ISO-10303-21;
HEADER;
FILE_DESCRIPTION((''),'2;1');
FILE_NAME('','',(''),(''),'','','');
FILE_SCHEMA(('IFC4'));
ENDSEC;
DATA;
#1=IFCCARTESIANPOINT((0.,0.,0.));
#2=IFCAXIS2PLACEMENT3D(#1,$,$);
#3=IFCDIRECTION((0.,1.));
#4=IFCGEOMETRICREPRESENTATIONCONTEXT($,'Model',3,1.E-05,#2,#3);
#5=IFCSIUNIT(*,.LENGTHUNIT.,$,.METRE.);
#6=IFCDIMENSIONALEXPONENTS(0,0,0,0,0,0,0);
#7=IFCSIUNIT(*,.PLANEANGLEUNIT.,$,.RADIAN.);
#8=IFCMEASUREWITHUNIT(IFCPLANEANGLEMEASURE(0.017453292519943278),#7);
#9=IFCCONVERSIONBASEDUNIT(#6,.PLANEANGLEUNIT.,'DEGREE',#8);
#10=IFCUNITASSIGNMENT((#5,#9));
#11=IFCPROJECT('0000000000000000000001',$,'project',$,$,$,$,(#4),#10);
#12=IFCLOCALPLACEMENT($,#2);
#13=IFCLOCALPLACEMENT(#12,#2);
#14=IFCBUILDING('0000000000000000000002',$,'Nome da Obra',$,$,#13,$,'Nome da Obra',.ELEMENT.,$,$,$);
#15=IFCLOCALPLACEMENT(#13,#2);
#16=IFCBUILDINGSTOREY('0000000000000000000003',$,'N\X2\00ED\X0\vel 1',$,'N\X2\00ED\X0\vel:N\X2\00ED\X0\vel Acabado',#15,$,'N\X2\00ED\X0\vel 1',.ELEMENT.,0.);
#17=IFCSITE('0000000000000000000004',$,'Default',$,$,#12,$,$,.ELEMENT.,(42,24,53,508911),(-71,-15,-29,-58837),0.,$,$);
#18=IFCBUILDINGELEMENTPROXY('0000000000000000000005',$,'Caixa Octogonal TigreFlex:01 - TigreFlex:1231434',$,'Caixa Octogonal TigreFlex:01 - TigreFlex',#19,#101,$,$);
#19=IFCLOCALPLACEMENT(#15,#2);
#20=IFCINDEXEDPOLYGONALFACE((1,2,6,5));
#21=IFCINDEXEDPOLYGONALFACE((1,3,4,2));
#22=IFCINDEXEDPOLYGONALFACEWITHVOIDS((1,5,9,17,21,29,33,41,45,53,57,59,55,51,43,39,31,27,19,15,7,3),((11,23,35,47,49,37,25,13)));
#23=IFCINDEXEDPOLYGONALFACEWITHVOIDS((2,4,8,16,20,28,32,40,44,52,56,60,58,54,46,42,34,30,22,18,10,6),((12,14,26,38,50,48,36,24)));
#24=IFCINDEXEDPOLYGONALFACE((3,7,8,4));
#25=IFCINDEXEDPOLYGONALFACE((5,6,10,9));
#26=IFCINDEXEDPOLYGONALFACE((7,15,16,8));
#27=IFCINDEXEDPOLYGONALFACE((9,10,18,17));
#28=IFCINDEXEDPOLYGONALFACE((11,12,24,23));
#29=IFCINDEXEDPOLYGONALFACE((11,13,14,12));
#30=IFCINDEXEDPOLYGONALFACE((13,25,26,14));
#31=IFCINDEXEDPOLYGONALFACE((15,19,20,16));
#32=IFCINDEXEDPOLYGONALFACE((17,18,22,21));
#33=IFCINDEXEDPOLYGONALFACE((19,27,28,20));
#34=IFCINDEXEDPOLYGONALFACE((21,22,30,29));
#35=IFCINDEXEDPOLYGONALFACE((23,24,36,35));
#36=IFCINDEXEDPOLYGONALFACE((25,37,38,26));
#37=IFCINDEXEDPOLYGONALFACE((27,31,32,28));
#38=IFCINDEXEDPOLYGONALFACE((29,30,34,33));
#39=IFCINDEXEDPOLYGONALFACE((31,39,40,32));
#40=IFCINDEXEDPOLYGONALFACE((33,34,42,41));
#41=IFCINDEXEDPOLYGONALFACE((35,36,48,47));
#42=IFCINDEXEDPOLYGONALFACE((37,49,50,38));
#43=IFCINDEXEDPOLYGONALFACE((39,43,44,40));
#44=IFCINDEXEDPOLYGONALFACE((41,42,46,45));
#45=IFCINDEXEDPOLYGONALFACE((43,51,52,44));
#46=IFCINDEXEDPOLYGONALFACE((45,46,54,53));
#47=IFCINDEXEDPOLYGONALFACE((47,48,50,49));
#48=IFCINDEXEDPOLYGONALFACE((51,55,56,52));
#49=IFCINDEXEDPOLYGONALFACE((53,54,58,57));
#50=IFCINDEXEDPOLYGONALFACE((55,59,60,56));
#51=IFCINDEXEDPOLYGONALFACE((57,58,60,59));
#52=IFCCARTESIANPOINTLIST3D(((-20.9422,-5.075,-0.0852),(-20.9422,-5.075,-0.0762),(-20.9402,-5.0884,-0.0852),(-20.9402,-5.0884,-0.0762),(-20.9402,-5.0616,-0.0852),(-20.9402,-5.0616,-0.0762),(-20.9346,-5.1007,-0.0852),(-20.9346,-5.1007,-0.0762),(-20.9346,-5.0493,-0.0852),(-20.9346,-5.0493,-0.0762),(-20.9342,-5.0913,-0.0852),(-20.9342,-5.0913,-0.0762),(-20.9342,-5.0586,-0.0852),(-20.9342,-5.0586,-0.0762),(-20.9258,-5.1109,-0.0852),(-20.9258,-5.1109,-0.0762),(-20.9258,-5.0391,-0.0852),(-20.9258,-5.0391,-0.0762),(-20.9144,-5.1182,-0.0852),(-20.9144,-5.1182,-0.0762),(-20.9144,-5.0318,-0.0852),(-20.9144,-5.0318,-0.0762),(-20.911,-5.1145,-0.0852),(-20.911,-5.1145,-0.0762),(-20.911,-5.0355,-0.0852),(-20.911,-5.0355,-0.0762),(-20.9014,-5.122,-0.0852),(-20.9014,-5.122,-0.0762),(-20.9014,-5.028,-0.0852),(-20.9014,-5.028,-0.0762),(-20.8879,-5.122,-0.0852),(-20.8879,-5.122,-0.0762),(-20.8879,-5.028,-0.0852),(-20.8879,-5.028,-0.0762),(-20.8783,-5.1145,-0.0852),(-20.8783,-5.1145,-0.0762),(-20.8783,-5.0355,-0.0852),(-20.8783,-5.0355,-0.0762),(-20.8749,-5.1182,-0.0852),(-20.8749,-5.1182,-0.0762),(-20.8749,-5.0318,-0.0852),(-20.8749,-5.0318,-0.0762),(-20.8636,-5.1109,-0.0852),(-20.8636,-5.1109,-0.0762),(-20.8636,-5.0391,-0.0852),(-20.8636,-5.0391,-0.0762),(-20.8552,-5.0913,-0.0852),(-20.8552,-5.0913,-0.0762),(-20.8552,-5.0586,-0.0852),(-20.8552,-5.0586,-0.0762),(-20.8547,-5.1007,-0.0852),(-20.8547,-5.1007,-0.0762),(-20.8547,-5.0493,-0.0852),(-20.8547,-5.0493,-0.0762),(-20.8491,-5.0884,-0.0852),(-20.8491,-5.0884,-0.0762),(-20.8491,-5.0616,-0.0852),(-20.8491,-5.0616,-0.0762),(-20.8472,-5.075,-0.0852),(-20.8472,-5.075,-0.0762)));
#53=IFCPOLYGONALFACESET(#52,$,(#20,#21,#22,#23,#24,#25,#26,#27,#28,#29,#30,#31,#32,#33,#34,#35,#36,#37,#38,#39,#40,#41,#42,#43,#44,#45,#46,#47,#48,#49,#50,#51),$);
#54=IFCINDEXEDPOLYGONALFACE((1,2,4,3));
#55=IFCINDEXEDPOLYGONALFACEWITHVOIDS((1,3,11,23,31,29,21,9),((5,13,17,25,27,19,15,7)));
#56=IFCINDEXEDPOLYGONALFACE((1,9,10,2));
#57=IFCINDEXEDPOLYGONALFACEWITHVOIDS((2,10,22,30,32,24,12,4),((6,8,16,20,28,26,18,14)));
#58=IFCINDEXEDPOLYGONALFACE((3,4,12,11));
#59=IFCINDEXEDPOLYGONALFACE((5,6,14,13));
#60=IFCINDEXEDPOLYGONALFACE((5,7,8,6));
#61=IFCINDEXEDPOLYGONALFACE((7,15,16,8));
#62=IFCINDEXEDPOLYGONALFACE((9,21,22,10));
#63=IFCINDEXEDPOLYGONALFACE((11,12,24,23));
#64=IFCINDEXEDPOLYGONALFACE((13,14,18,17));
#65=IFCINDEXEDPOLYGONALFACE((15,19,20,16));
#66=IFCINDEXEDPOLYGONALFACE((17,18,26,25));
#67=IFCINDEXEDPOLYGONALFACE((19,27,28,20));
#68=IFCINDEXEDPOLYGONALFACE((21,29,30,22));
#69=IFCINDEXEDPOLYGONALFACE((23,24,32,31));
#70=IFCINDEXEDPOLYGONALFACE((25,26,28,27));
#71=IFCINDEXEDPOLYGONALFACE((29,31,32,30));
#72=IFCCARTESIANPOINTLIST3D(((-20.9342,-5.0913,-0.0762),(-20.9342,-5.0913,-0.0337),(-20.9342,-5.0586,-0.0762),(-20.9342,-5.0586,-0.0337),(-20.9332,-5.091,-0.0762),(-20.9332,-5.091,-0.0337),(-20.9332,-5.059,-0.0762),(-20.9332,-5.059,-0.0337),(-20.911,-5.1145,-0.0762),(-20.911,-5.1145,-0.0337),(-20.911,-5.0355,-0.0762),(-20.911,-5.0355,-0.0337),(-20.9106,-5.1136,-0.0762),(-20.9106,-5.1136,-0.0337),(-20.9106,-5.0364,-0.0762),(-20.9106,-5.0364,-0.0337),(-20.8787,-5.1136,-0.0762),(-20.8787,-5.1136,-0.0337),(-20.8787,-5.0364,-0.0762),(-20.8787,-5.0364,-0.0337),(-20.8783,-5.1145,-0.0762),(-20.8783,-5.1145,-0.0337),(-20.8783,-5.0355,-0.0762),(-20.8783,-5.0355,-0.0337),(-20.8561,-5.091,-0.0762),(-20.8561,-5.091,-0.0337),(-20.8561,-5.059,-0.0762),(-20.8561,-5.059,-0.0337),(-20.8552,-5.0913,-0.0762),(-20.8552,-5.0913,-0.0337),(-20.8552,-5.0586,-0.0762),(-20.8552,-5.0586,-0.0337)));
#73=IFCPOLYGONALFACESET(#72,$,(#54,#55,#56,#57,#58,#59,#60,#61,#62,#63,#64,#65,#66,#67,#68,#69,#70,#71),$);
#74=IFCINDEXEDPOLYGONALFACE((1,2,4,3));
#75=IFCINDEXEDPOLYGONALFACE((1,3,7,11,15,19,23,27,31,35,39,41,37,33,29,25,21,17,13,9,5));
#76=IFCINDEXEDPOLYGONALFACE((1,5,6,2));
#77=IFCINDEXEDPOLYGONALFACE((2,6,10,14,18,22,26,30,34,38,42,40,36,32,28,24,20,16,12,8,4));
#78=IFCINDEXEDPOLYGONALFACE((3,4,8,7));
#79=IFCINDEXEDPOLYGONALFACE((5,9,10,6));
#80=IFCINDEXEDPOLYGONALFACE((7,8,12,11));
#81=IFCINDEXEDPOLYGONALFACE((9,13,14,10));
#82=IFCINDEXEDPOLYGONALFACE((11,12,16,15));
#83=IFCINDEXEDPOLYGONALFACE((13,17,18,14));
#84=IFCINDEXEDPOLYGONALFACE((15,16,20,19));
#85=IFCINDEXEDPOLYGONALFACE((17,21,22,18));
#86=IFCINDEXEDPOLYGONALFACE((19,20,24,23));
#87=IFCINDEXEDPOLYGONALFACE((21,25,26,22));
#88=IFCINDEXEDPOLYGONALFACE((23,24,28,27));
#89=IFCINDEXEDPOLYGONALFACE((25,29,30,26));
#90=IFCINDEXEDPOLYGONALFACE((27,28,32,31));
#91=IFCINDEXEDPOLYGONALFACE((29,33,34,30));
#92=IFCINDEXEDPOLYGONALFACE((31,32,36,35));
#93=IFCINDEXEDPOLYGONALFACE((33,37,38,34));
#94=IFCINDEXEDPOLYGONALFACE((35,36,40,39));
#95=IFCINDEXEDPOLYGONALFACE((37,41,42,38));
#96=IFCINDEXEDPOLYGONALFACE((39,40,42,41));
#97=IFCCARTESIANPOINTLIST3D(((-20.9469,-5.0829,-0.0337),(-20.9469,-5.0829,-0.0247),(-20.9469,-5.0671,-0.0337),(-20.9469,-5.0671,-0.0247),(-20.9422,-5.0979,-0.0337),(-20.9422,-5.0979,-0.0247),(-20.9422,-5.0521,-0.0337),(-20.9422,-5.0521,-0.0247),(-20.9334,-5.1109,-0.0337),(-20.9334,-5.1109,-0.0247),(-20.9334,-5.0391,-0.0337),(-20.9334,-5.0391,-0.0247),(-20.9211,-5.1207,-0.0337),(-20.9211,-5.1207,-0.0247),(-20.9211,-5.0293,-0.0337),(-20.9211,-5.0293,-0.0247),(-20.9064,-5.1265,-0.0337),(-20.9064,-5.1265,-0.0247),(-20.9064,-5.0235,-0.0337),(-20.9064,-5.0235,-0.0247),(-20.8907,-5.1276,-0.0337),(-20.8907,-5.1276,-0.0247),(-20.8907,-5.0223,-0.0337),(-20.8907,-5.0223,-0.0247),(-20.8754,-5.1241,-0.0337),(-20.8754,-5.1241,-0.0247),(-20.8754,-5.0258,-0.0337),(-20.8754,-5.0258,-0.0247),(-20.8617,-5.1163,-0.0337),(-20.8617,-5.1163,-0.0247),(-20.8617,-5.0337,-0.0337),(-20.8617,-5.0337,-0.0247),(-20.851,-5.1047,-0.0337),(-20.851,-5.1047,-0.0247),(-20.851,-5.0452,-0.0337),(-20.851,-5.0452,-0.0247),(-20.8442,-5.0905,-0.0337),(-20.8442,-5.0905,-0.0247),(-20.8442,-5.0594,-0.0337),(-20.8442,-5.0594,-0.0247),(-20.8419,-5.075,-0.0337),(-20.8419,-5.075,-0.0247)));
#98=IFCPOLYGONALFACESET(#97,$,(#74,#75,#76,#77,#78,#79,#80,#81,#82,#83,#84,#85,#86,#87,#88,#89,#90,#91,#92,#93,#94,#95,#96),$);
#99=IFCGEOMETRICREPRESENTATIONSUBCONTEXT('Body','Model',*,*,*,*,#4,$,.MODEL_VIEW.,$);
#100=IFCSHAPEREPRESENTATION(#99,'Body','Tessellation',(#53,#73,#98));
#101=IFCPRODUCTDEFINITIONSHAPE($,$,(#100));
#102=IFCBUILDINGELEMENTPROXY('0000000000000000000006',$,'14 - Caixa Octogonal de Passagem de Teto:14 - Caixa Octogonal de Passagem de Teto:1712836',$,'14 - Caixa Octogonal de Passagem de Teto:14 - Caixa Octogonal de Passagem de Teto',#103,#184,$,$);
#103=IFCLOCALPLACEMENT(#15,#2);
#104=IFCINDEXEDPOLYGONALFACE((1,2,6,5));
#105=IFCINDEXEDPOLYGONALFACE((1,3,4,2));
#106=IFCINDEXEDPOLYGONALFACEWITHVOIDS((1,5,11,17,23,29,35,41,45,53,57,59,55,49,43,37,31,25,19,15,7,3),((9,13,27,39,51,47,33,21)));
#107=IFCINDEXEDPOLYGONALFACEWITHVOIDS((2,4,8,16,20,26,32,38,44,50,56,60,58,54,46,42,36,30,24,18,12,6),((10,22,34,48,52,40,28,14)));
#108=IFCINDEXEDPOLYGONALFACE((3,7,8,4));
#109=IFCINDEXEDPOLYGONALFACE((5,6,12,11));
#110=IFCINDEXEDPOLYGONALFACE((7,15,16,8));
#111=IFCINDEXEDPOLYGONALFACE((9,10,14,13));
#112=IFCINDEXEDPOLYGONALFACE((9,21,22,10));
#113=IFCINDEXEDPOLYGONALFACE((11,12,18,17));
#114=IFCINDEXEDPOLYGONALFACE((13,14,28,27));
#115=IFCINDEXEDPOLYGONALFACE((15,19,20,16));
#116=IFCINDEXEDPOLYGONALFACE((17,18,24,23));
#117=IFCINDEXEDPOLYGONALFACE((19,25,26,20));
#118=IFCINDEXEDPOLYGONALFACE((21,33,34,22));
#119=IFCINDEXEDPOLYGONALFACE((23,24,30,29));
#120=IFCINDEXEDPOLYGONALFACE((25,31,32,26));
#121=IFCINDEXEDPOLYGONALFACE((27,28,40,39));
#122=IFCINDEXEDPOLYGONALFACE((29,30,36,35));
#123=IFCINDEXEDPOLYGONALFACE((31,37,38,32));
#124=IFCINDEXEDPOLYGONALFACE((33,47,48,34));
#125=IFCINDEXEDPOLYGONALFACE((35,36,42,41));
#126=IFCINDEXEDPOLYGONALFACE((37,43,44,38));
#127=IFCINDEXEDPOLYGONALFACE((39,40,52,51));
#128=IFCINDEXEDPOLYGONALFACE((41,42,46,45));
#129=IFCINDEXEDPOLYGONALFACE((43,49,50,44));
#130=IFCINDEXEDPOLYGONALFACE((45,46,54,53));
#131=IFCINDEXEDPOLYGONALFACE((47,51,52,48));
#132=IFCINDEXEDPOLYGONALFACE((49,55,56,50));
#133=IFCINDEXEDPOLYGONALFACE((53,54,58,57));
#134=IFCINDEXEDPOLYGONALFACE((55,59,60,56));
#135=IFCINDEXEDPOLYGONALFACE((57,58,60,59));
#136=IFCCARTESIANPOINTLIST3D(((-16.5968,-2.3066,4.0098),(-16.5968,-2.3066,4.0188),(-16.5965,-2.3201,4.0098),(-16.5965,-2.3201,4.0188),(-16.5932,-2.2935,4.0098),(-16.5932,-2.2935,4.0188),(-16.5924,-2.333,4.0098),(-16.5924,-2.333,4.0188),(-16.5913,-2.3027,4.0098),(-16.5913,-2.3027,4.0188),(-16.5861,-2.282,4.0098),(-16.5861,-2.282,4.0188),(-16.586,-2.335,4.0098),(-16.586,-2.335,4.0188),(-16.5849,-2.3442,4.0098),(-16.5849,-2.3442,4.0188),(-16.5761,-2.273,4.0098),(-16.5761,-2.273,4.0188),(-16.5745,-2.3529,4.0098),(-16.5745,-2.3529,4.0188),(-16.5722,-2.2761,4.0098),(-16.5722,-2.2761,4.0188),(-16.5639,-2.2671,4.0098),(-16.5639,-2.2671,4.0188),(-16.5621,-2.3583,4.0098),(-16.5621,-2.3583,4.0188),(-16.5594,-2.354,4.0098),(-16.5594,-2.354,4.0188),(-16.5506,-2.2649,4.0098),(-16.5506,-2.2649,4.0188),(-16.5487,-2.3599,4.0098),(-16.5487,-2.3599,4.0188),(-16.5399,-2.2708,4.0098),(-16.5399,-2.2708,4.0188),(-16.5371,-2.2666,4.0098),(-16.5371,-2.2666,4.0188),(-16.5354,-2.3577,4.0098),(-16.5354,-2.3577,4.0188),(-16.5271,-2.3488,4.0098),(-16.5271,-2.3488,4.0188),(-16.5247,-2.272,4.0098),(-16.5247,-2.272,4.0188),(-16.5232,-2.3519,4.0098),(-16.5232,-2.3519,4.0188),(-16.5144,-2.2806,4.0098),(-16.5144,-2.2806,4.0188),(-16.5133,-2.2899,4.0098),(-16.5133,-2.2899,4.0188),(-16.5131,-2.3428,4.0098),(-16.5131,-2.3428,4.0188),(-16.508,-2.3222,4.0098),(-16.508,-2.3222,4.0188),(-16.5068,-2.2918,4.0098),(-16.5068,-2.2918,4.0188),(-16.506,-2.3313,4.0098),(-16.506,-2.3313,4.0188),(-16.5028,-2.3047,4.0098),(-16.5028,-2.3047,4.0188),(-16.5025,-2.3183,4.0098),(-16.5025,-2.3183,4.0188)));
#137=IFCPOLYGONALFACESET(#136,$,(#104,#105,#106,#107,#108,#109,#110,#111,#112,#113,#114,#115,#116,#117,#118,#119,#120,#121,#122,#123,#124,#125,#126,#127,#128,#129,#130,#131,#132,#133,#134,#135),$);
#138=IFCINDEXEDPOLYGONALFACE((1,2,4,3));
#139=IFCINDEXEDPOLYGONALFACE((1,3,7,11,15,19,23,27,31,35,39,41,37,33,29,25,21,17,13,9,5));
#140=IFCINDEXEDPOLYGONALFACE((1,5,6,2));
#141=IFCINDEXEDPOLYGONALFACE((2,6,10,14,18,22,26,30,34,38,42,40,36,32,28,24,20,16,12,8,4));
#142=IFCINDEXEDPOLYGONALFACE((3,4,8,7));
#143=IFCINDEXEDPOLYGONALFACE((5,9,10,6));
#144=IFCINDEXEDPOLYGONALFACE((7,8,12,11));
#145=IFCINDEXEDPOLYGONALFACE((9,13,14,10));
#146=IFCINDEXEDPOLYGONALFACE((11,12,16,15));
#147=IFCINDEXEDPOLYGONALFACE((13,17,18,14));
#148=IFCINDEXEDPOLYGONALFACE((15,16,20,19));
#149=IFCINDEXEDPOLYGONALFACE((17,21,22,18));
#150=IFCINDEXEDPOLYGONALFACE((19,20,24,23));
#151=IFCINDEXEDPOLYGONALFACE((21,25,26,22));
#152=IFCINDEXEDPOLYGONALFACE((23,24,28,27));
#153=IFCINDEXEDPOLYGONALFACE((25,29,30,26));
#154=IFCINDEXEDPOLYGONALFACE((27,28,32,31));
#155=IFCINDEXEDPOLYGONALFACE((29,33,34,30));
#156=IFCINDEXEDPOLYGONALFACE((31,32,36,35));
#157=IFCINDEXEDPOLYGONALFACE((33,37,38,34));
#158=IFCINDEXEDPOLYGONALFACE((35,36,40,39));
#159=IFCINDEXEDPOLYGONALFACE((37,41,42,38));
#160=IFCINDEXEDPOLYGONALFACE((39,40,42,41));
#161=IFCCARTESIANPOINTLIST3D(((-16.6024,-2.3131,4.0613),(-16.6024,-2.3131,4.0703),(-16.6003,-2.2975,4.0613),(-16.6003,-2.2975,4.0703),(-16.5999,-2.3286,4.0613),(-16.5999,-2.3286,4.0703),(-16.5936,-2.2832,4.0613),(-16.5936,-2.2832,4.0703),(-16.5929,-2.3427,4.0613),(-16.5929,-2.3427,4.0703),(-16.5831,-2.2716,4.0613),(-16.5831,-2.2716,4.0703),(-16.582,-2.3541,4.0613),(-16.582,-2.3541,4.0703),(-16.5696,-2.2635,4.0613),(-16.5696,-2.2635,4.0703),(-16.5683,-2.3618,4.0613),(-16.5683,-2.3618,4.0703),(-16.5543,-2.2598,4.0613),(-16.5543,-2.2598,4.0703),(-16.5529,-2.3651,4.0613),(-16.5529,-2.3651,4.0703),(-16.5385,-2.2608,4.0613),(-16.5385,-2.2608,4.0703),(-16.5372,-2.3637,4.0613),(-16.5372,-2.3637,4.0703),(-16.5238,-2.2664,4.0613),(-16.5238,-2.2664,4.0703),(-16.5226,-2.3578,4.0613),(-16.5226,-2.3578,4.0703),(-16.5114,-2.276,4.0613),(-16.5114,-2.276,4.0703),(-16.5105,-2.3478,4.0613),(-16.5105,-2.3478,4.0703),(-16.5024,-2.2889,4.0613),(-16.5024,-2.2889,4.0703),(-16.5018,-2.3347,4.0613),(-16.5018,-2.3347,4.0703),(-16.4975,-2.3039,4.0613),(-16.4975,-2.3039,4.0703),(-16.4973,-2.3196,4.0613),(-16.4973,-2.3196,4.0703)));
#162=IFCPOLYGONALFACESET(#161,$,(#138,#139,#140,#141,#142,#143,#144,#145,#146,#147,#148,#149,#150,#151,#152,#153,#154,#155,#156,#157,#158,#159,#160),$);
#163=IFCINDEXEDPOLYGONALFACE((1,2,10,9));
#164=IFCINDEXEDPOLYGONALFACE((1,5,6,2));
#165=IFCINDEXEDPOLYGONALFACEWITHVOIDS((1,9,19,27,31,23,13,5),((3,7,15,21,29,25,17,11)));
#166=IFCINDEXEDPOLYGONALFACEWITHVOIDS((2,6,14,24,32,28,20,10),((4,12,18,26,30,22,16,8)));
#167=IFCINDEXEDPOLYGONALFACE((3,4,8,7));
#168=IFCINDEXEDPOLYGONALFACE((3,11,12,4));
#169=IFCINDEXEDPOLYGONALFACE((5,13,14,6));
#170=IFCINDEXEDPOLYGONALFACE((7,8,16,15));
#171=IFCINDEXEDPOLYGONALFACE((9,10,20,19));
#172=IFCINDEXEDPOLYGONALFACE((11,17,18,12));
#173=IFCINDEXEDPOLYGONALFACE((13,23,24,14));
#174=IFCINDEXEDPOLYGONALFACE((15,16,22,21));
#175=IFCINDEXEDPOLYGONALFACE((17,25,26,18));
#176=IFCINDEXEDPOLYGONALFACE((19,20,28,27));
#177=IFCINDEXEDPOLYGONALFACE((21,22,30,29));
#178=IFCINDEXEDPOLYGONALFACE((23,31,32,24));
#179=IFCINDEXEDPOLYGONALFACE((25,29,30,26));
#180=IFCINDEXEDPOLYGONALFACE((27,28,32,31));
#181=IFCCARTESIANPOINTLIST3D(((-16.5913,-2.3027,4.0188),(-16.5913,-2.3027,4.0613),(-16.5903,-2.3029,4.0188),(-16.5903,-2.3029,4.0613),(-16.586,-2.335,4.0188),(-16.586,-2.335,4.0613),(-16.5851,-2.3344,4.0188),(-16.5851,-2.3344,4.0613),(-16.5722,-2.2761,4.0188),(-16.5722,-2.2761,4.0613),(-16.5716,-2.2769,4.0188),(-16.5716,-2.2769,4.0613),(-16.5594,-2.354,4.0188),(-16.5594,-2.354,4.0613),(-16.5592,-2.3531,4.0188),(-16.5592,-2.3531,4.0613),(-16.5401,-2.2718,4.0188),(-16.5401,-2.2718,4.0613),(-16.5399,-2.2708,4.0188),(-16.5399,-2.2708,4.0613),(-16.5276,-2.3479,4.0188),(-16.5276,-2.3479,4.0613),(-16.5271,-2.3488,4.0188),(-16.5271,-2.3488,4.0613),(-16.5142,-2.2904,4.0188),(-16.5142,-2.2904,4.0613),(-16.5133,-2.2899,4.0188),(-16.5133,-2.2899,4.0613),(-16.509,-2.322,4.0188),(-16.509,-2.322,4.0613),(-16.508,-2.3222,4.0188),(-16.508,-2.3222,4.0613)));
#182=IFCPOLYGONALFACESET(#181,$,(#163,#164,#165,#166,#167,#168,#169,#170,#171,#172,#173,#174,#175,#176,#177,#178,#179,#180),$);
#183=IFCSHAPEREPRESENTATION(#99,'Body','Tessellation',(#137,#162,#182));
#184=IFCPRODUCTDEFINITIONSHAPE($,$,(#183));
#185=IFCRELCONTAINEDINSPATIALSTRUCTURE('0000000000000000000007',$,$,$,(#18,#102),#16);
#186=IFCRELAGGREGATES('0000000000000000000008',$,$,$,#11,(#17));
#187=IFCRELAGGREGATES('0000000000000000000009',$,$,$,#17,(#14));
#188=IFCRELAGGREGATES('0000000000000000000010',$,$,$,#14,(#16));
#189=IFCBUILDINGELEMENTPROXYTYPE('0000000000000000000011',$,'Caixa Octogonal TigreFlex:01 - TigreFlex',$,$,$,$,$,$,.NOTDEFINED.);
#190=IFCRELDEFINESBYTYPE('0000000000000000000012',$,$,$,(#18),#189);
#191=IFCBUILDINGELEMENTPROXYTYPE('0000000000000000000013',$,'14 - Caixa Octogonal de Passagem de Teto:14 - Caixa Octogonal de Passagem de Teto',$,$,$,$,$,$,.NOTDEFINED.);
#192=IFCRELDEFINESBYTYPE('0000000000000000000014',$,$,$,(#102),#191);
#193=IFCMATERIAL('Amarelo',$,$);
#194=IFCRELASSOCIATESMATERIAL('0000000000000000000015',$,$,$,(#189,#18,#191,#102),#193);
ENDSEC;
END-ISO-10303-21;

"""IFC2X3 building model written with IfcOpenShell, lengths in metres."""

from ifc_helpers import new_model, entity, si_unit, converted_unit, direction, frame, frame_2d, origin, origin_2d_with_axis, place, context, subcontext, project, spatial, polyline, circle_curve, parameter, trimmed, segment, composite_curve, circle, outline, extrude, source, transform, mapped, material, type_object, type_shapes, element, save


model = new_model("IFC2X3")

# Units and contexts
model_context = context("Model", 3, precision=1e-05, world=origin(), true_north=direction((0.0, 1.0)))
body_context = subcontext(model_context, "Body", "Model", "MODEL_VIEW")
ifc_project = project(units=[si_unit("LENGTHUNIT", "METRE"), converted_unit("PLANEANGLEUNIT", "DEGREE", entity("IfcPlaneAngleMeasure", 0.017453292519943278), si_unit("PLANEANGLEUNIT", "RADIAN"), dimensions=[0, 0, 0, 0, 0, 0, 0])], contexts=[model_context])

# Site, building, storey
site_placement = place(None, origin())
site = spatial("IfcSite", under=ifc_project, at=site_placement, Name="Default", CompositionType="ELEMENT", RefLatitude=(42, 24, 53, 508911), RefLongitude=(-71, -15, -29, -58837), RefElevation=0.0)
building_placement = place(site_placement, origin())
building = spatial("IfcBuilding", under=site, at=building_placement, Name="Nome da Obra", LongName="Nome da Obra", CompositionType="ELEMENT")
storey_placement = place(building_placement, origin())
storey = spatial("IfcBuildingStorey", under=building, at=storey_placement, Name="Nível 1", ObjectType="Nível:Nível Acabado", LongName="Nível 1", CompositionType="ELEMENT", Elevation=0.0)

# Building element proxies
ifc_material_1 = material(Name="Amarelo")
building_element_proxy_type_1 = type_object("IfcBuildingElementProxyType", Name="Caixa Octogonal TigreFlex:01 - TigreFlex", PredefinedType="NOTDEFINED", material=ifc_material_1)
shared_shape_1 = source(origin(), body_context, "Body", "SweptSolid", [
    extrude(outline(composite_curve([segment(trimmed(circle_curve(origin_2d_with_axis(), 0.0475), [parameter(180.0)], [parameter(360.0)], True, "PARAMETER"), True, "CONTINUOUS"), segment(trimmed(circle_curve(origin_2d_with_axis(), 0.0475), [parameter(0.0)], [parameter(180.0)], True, "PARAMETER"), True, "CONTINUOUS")], self_intersect=False), holes=[polyline([(-0.0395, 0.0164), (-0.0164, 0.0395), (0.0164, 0.0395), (0.0395, 0.0164), (0.0395, -0.0164), (0.0164, -0.0395), (-0.0164, -0.0395), (-0.0395, -0.0164), (-0.0395, 0.0164)])]), frame((0.0, 0.0, -0.0302)), (0.0, 0.0, 1.0), 0.009),
    extrude(outline(polyline([(-0.0164, -0.0395), (0.0164, -0.0395), (0.0395, -0.0164), (0.0395, 0.0164), (0.0164, 0.0395), (-0.0164, 0.0395), (-0.0395, 0.0164), (-0.0395, -0.0164), (-0.0164, -0.0395)]), holes=[polyline([(-0.016, -0.0386), (-0.0386, -0.016), (-0.0386, 0.016), (-0.016, 0.0386), (0.016, 0.0386), (0.0386, 0.016), (0.0386, -0.016), (0.016, -0.0386), (-0.016, -0.0386)])]), frame((0.0, 0.0, -0.0212), z_axis=(0.0, 0.0, 1.0), x_axis=(0.0, -1.0, 0.0)), (0.0, 0.0, 1.0), 0.0425),
    extrude(circle(Radius=0.0528, at=frame_2d((0.0, 0.0), x_axis=(1.0, 0.0))), frame((0.0, 0.0, 0.0213)), (0.0, 0.0, 1.0), 0.009),
])
type_shapes(building_element_proxy_type_1, [shared_shape_1])
for number, where, name in (
    (1, (-20.8947, -5.075, -0.055), "Caixa Octogonal TigreFlex:01 - TigreFlex:1231434"),
):
    element("IfcBuildingElementProxy", number, at=place(storey_placement, frame(where)), inside=storey, type_object=building_element_proxy_type_1, material=ifc_material_1, Name=name, ObjectType="Caixa Octogonal TigreFlex:01 - TigreFlex", context=body_context, shape_type="MappedRepresentation", body=[
        mapped(shared_shape_1, transform((0.0, 0.0, 0.0), scale=1.0)),
    ])
building_element_proxy_type_2 = type_object("IfcBuildingElementProxyType", Name="14 - Caixa Octogonal de Passagem de Teto:14 - Caixa Octogonal de Passagem de Teto", PredefinedType="NOTDEFINED", material=ifc_material_1)
shared_shape_2 = source(origin(), body_context, "Body", "SweptSolid", [
    extrude(outline(composite_curve([segment(trimmed(circle_curve(origin_2d_with_axis(), 0.0475), [parameter(180.0)], [parameter(360.0)], True, "PARAMETER"), True, "CONTINUOUS"), segment(trimmed(circle_curve(origin_2d_with_axis(), 0.0475), [parameter(0.0)], [parameter(180.0)], True, "PARAMETER"), True, "CONTINUOUS")], self_intersect=False), holes=[polyline([(-0.0395, 0.0164), (-0.0164, 0.0395), (0.0164, 0.0395), (0.0395, 0.0164), (0.0395, -0.0164), (0.0164, -0.0395), (-0.0164, -0.0395), (-0.0395, -0.0164), (-0.0395, 0.0164)])]), frame((0.0, 0.0, 2.7698)), (0.0, 0.0, 1.0), 0.009),
    extrude(circle(Radius=0.0528, at=frame_2d((0.0, 0.0), x_axis=(1.0, 0.0))), frame((0.0, 0.0, 2.8213)), (0.0, 0.0, 1.0), 0.009),
    extrude(outline(polyline([(-0.0164, -0.0395), (0.0164, -0.0395), (0.0395, -0.0164), (0.0395, 0.0164), (0.0164, 0.0395), (-0.0164, 0.0395), (-0.0395, 0.0164), (-0.0395, -0.0164), (-0.0164, -0.0395)]), holes=[polyline([(-0.016, -0.0386), (-0.0386, -0.016), (-0.0386, 0.016), (-0.016, 0.0386), (0.016, 0.0386), (0.0386, 0.016), (0.0386, -0.016), (0.016, -0.0386), (-0.016, -0.0386)])]), frame((0.0, 0.0, 2.7788), z_axis=(0.0, 0.0, 1.0), x_axis=(0.0, -1.0, 0.0)), (0.0, 0.0, 1.0), 0.0425),
])
type_shapes(building_element_proxy_type_2, [shared_shape_2])
proxy_1_placement = place(storey_placement, frame((-16.5496, -2.3124, 1.24), z_axis=(0.0, 0.0, 1.0), x_axis=(0.986833, 0.161741, 0.0)))
element("IfcBuildingElementProxy", 2, at=proxy_1_placement, inside=storey, type_object=building_element_proxy_type_2, material=ifc_material_1, Name="14 - Caixa Octogonal de Passagem de Teto:14 - Caixa Octogonal de Passagem de Teto:1712836", ObjectType="14 - Caixa Octogonal de Passagem de Teto:14 - Caixa Octogonal de Passagem de Teto", context=body_context, shape_type="MappedRepresentation", body=[
    mapped(shared_shape_2, transform((0.0, 0.0, 0.0), scale=1.0)),
])

save(model, "model.ifc")
